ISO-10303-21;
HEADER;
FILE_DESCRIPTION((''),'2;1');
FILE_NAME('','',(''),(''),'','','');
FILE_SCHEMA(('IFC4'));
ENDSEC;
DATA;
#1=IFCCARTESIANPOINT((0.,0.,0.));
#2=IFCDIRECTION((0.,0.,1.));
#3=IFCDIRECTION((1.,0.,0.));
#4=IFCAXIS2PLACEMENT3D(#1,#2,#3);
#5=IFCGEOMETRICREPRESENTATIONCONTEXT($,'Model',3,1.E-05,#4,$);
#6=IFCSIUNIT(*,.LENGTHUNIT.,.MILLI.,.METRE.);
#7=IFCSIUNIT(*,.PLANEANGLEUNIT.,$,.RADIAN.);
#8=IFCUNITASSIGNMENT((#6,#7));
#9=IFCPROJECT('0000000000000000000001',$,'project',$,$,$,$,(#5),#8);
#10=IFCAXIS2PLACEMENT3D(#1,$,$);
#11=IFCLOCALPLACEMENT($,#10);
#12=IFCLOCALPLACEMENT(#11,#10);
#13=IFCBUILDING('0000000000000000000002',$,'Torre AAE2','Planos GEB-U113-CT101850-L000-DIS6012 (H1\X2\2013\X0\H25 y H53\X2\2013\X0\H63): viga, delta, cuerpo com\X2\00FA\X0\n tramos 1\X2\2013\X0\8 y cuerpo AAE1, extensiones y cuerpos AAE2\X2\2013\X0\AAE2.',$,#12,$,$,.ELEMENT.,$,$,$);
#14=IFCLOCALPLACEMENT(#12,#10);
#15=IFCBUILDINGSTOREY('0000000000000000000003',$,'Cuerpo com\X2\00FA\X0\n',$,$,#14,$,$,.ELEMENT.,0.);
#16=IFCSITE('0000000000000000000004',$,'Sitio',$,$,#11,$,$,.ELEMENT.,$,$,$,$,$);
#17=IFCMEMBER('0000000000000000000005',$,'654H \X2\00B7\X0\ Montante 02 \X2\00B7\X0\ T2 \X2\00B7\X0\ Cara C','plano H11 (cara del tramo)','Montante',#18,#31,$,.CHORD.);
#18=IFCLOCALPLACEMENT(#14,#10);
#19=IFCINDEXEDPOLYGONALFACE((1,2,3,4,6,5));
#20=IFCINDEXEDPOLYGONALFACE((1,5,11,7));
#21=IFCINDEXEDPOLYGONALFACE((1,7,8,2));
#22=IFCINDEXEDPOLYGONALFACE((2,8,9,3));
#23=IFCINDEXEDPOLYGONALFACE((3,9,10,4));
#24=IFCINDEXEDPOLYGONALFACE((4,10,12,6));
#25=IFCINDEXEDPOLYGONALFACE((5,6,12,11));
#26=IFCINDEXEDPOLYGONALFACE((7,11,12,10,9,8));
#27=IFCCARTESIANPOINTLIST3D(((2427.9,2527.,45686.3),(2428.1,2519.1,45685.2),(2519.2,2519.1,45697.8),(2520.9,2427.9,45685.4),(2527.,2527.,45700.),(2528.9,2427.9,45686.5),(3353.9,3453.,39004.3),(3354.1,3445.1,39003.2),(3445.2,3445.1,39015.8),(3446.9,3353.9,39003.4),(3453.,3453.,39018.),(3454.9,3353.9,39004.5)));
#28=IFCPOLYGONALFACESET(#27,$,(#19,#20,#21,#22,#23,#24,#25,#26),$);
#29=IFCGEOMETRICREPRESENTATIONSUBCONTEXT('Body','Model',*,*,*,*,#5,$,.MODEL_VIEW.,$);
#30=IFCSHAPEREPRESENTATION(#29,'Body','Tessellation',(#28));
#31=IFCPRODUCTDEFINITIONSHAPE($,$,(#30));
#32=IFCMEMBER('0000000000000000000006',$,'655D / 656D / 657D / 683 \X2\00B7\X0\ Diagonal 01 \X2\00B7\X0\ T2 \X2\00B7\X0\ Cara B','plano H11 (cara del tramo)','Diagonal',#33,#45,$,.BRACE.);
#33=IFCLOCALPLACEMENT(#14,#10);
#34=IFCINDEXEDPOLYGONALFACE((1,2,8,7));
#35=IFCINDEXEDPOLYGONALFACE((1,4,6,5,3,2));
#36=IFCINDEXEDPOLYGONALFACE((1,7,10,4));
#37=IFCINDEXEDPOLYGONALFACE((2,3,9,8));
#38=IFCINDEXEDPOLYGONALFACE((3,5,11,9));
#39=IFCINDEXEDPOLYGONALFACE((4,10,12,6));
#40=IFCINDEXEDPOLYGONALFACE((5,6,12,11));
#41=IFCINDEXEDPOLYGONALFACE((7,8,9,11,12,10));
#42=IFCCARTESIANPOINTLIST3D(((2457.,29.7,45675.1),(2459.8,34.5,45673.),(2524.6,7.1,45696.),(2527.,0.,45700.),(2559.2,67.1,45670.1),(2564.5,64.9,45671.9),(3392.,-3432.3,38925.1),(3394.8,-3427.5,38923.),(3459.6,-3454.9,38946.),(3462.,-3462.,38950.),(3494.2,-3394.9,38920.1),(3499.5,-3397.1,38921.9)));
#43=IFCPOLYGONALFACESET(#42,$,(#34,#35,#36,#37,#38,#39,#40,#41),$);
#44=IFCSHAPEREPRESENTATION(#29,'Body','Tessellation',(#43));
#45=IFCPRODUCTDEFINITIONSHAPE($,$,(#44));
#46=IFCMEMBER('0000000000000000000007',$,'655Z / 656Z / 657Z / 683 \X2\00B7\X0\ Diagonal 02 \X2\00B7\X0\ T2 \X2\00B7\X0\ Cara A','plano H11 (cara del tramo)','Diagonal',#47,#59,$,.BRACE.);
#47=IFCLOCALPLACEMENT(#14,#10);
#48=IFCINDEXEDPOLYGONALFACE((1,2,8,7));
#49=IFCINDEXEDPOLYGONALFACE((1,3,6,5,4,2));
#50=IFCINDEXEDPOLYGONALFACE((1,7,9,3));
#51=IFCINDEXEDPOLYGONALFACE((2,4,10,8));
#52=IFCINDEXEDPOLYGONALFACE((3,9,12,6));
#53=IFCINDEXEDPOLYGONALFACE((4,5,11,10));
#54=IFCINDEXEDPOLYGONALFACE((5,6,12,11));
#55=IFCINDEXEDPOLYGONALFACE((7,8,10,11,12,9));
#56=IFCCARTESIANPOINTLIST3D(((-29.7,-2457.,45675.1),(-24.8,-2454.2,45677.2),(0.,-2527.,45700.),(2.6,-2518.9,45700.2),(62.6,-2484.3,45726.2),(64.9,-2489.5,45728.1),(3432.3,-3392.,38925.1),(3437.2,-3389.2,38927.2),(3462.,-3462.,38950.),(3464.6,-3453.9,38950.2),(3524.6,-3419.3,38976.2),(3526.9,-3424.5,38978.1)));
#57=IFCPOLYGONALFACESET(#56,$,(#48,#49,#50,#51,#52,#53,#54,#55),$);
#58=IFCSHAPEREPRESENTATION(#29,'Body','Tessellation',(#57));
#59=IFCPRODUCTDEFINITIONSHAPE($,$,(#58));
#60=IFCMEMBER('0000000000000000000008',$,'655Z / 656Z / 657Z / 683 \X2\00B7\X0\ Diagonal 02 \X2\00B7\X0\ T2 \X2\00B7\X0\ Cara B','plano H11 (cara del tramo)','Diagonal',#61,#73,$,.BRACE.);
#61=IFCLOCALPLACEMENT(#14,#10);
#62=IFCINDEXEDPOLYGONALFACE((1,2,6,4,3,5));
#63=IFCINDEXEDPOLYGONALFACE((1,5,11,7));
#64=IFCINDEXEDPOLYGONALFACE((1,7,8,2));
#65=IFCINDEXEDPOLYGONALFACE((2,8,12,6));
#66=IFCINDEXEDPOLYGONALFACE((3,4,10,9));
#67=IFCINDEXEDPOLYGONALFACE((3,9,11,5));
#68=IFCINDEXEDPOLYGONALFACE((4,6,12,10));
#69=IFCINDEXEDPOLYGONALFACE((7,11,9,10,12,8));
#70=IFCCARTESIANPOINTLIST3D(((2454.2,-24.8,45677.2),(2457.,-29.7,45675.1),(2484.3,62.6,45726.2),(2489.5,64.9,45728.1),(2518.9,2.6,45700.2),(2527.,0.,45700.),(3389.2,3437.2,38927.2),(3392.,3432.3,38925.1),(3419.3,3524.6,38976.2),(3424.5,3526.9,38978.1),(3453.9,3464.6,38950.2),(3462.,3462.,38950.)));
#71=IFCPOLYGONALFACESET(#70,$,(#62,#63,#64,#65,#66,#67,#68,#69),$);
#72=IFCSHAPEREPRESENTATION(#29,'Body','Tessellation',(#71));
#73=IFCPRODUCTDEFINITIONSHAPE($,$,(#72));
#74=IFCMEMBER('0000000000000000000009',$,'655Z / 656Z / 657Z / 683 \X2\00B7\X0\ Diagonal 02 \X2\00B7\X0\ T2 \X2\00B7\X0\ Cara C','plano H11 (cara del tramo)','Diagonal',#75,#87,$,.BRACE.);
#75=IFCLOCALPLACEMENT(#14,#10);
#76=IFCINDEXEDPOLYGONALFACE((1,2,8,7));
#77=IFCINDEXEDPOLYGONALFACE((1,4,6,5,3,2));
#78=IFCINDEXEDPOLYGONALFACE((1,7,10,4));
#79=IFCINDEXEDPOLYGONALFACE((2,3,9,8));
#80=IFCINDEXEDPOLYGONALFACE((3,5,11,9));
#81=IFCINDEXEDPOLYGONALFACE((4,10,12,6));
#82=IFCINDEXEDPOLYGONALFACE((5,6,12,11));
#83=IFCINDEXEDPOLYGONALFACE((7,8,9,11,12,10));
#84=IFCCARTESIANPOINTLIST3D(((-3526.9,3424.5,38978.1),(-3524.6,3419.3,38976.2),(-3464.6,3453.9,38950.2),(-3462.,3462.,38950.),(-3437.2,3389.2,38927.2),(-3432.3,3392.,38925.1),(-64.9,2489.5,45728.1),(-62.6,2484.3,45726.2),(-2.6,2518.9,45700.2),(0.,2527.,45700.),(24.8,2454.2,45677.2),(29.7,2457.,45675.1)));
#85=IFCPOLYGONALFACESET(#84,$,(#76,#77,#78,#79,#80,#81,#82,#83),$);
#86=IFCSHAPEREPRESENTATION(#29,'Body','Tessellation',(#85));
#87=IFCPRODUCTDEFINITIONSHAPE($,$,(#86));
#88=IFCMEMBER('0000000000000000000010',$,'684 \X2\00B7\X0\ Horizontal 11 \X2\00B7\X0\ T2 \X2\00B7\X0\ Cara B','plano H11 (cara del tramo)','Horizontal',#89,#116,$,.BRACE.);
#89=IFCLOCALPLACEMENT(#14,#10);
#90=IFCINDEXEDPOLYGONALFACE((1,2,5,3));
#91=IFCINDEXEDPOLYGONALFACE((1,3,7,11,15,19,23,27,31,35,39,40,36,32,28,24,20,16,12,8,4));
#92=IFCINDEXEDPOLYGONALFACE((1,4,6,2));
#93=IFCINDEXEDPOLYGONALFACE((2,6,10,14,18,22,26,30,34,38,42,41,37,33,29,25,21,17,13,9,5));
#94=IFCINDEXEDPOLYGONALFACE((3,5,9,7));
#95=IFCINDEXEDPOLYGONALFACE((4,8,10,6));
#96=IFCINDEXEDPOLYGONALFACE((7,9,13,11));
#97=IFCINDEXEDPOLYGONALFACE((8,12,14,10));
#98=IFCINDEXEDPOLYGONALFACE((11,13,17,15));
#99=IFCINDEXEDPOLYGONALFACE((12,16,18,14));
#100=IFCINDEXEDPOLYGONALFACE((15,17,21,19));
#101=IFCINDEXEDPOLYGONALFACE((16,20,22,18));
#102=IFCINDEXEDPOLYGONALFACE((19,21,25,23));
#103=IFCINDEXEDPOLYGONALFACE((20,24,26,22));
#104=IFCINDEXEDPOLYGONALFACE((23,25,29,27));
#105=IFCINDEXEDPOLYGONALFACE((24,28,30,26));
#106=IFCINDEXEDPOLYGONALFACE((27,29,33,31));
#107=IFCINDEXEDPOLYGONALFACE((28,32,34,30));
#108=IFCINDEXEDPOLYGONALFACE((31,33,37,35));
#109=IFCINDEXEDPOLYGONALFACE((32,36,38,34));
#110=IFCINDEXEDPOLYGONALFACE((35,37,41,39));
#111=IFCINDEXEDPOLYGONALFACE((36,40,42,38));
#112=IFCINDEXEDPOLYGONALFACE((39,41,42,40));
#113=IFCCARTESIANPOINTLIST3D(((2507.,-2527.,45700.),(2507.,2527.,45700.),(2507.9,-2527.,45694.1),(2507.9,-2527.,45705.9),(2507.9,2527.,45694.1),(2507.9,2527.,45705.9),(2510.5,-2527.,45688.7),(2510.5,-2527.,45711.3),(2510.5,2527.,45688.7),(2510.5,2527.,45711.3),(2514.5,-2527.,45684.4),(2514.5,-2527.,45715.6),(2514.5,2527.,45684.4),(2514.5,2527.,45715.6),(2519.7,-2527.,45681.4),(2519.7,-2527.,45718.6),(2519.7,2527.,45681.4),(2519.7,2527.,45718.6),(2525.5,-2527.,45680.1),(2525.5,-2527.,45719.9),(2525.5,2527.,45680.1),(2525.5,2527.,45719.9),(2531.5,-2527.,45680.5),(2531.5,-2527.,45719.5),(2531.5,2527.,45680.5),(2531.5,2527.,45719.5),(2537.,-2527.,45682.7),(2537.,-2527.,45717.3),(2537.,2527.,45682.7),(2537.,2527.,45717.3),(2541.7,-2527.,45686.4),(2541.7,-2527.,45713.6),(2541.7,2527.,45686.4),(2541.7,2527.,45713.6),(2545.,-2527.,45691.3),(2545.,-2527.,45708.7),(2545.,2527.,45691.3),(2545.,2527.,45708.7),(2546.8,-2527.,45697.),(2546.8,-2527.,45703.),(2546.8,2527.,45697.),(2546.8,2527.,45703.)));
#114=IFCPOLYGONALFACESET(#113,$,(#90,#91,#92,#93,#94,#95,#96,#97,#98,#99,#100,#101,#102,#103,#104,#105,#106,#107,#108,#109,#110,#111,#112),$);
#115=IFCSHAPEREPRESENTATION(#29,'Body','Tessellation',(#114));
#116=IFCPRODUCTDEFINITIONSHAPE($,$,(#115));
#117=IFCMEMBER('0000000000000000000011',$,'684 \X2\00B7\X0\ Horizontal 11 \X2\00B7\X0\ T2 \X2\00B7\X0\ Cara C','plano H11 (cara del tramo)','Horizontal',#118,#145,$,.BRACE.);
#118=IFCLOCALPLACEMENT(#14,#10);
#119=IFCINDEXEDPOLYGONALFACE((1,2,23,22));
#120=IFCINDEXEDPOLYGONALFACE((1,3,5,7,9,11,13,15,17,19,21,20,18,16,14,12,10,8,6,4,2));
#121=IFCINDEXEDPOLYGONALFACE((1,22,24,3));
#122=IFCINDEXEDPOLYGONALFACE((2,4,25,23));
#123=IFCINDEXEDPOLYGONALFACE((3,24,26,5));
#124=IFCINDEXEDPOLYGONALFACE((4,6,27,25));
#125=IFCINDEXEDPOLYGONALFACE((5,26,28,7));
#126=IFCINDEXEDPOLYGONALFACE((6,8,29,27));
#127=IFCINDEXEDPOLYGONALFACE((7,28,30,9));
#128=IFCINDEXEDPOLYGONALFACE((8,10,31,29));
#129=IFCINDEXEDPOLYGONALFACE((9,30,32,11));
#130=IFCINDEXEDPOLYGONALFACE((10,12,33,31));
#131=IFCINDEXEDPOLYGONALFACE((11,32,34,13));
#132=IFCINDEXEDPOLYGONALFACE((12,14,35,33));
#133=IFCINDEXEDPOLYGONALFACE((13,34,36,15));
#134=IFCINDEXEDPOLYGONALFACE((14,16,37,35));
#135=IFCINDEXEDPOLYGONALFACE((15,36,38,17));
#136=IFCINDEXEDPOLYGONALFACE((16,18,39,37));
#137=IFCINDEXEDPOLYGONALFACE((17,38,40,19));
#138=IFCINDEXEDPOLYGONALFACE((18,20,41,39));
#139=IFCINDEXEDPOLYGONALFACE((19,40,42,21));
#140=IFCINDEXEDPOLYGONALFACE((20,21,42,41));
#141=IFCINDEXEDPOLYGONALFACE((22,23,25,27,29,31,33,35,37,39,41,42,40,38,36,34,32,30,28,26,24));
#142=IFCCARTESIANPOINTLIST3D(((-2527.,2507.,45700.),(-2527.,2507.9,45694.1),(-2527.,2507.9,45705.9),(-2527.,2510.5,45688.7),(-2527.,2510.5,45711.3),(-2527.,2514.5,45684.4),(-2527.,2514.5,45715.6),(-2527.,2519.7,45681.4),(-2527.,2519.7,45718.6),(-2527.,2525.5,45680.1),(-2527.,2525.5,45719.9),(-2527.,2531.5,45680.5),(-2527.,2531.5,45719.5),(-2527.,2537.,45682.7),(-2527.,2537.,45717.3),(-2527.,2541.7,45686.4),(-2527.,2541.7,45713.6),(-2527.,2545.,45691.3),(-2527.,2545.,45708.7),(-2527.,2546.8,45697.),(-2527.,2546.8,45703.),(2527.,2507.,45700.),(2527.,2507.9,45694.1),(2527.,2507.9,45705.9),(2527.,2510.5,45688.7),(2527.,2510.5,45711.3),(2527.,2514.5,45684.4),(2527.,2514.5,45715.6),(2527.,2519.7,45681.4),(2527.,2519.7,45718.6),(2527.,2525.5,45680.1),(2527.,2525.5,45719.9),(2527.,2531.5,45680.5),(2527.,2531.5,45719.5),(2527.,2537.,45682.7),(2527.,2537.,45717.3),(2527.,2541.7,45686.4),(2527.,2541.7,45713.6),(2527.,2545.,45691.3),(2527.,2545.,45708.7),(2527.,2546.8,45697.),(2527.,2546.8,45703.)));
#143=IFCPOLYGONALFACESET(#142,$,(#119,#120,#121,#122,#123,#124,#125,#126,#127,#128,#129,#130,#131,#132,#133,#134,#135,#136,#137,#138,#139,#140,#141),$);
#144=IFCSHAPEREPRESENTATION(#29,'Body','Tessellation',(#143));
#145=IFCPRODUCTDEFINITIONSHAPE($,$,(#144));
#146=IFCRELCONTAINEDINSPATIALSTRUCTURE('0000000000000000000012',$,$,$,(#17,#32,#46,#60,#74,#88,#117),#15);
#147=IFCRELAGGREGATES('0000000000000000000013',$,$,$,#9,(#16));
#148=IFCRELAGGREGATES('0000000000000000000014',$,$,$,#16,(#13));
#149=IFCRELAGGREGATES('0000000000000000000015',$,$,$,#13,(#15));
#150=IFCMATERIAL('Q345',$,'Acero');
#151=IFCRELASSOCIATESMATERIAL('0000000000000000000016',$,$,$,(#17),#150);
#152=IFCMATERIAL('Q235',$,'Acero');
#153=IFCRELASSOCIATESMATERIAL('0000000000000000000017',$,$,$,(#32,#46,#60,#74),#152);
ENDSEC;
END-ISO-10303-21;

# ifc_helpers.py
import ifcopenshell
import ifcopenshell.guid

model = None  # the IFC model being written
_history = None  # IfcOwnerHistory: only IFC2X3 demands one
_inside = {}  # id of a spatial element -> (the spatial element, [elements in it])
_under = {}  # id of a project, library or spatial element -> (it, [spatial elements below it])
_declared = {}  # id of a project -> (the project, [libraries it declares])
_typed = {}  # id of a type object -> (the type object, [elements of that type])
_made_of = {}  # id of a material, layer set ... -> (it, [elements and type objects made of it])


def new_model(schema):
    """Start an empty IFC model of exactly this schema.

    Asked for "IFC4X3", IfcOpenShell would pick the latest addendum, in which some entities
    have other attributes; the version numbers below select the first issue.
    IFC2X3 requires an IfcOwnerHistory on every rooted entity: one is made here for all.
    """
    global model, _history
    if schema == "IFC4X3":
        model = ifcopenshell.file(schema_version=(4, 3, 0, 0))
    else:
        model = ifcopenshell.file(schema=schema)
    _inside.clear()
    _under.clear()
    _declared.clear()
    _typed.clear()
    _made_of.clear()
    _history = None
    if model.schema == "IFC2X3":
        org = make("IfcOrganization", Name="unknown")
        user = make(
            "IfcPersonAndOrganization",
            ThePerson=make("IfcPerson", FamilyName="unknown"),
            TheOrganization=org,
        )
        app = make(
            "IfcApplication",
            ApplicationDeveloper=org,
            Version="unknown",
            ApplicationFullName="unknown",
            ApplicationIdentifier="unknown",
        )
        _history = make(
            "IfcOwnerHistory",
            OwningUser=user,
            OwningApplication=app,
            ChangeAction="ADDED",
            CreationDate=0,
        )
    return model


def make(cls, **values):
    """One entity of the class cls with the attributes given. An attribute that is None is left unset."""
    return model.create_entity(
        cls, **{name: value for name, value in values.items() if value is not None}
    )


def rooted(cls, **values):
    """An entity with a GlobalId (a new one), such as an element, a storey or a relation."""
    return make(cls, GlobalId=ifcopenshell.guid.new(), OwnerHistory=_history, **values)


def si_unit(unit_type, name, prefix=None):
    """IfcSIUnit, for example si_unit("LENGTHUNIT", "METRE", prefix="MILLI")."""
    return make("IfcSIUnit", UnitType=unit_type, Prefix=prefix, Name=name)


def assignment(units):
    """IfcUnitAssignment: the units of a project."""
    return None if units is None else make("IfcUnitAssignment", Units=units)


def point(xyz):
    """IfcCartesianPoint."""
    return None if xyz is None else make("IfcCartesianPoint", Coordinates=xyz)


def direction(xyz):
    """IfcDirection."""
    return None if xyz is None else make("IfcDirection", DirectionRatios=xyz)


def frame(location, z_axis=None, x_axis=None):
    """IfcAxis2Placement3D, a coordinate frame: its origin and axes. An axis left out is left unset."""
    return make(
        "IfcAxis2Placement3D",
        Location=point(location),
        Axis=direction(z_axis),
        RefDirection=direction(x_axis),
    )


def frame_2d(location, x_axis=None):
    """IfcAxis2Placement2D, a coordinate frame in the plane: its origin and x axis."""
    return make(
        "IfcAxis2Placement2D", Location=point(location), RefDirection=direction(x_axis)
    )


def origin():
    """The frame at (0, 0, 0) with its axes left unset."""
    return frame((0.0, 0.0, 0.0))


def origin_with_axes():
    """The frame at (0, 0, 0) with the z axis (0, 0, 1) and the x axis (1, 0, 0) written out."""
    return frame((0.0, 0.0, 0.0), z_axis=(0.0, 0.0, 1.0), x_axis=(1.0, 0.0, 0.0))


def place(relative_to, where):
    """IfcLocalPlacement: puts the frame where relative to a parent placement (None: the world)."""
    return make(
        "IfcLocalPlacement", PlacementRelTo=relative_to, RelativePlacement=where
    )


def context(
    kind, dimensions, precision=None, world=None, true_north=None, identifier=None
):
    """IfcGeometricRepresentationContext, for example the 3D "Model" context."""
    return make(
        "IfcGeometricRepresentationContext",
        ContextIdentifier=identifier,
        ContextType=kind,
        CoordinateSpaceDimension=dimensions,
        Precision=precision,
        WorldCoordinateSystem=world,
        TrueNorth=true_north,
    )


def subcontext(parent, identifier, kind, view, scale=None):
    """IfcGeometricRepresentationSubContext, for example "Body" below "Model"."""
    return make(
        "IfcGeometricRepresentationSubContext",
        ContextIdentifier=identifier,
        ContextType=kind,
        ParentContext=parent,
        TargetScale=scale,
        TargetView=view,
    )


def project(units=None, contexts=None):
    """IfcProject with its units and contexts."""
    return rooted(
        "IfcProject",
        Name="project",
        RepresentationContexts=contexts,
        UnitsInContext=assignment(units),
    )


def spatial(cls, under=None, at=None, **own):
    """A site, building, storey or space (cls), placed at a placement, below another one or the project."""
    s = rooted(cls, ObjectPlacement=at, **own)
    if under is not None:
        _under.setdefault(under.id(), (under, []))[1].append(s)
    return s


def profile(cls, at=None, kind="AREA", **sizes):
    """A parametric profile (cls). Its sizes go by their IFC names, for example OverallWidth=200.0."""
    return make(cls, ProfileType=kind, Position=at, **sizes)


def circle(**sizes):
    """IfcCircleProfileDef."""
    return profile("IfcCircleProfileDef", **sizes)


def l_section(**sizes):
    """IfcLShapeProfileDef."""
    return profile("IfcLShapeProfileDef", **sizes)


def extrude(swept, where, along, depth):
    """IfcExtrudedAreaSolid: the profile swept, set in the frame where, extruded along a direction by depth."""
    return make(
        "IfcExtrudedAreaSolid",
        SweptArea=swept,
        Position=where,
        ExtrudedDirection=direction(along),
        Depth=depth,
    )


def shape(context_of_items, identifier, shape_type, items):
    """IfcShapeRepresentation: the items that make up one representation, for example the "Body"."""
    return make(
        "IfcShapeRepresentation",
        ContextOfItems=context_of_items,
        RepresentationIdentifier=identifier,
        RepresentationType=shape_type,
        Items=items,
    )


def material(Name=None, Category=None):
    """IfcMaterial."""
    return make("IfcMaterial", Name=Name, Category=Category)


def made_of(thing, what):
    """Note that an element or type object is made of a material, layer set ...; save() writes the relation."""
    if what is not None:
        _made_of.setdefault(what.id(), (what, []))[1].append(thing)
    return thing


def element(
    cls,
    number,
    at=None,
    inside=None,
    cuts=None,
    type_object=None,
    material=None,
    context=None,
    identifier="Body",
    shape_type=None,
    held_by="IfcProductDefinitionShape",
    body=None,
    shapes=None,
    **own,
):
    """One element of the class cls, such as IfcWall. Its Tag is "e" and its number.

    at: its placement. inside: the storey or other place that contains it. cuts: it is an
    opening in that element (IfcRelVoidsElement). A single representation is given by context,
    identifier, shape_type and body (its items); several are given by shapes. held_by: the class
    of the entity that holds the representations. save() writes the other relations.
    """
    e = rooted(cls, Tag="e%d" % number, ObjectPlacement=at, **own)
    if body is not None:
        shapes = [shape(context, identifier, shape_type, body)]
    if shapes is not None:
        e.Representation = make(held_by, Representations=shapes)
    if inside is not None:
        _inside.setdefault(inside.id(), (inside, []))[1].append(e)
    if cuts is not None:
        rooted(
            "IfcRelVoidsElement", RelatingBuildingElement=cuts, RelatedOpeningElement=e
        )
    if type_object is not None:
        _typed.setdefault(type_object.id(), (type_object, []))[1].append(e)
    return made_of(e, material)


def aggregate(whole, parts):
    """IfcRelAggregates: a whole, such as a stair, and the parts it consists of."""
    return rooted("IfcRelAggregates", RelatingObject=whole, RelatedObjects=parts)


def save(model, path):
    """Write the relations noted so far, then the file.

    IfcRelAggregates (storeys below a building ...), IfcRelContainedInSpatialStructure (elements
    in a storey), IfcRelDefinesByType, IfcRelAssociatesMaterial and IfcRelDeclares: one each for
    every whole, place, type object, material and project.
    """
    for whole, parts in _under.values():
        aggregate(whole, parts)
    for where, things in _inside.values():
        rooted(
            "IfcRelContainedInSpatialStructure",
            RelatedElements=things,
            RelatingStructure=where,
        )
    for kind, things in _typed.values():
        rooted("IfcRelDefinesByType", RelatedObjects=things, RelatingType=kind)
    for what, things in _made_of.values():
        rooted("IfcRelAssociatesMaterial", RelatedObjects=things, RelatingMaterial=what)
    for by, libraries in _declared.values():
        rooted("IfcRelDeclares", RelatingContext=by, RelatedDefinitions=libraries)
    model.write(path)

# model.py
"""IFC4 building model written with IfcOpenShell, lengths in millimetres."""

from ifc_helpers import new_model, si_unit, frame, frame_2d, origin, origin_with_axes, place, context, subcontext, project, spatial, circle, l_section, extrude, material, element, save


model = new_model("IFC4")

# Units and contexts
model_context = context("Model", 3, precision=1e-05, world=origin_with_axes())
body_context = subcontext(model_context, "Body", "Model", "MODEL_VIEW")
ifc_project = project(units=[si_unit("LENGTHUNIT", "METRE", prefix="MILLI"), si_unit("PLANEANGLEUNIT", "RADIAN")], contexts=[model_context])

# Site, building, storey
site_placement = place(None, origin())
site = spatial("IfcSite", under=ifc_project, at=site_placement, Name="Sitio", CompositionType="ELEMENT")
building_placement = place(site_placement, origin())
building = spatial("IfcBuilding", under=site, at=building_placement, Name="Torre AAE2", Description="Planos GEB-U113-CT101850-L000-DIS6012 (H1–H25 y H53–H63): viga, delta, cuerpo común tramos 1–8 y cuerpo AAE1, extensiones y cuerpos AAE2–AAE2.", CompositionType="ELEMENT")
storey_placement = place(building_placement, origin())
storey = spatial("IfcBuildingStorey", under=building, at=storey_placement, Name="Cuerpo común", CompositionType="ELEMENT", Elevation=0.0)

# Members
ifc_material_1 = material(Name="Q235", Category="Acero")
ifc_material_2 = material(Name="Q345", Category="Acero")
for number, where, z_axis, x_axis, name in (
    (1, (2527.0, 2527.0, 45700.0), (0.135994, 0.135994, -0.981331), (0.018668, -0.99071, -0.134707), "654H · Montante 02 · T2 · Cara C"),
):
    element("IfcMember", number, at=place(storey_placement, frame(where, z_axis=z_axis, x_axis=x_axis)), inside=storey, material=ifc_material_2, Name=name, Description="plano H11 (cara del tramo)", ObjectType="Montante", PredefinedType="CHORD", context=body_context, shape_type="SweptSolid", body=[
        extrude(l_section(Depth=100.0, Width=100.0, Thickness=8.0, at=frame_2d((50.0, 50.0))), None, (0.0, 0.0, 1.0), 6809.1),
    ])
for number, where, z_axis, x_axis, name in (
    (2, (2527.0, 0.0, 45700.0), (0.122327, -0.452937, -0.88311), (-0.874879, 0.370937, -0.311437), "655D / 656D / 657D / 683 · Diagonal 01 · T2 · Cara B"),
    (3, (0.0, -2527.0, 45700.0), (0.452937, -0.122327, -0.88311), (-0.370937, 0.874879, -0.311437), "655Z / 656Z / 657Z / 683 · Diagonal 02 · T2 · Cara A"),
    (4, (2527.0, 0.0, 45700.0), (0.122327, 0.452937, -0.88311), (-0.874879, -0.370937, -0.311437), "655Z / 656Z / 657Z / 683 · Diagonal 02 · T2 · Cara B"),
    (5, (0.0, 2527.0, 45700.0), (-0.452937, 0.122327, -0.88311), (0.370937, -0.874879, -0.311437), "655Z / 656Z / 657Z / 683 · Diagonal 02 · T2 · Cara C"),
):
    element("IfcMember", number, at=place(storey_placement, frame(where, z_axis=z_axis, x_axis=x_axis)), inside=storey, material=ifc_material_1, Name=name, Description="plano H11 (cara del tramo)", ObjectType="Diagonal", PredefinedType="BRACE", context=body_context, shape_type="SweptSolid", body=[
        extrude(l_section(Depth=80.0, Width=80.0, Thickness=6.0, at=frame_2d((40.0, 40.0))), None, (0.0, 0.0, 1.0), 7643.4),
    ])
for number, where, z_axis, x_axis, name in (
    (6, (2527.0, -2527.0, 45700.0), (0.0, 1.0, 0.0), (-1.0, 0.0, 0.0), "684 · Horizontal 11 · T2 · Cara B"),
    (7, (2527.0, 2527.0, 45700.0), (-1.0, 0.0, 0.0), (0.0, -1.0, 0.0), "684 · Horizontal 11 · T2 · Cara C"),
):
    element("IfcMember", number, at=place(storey_placement, frame(where, z_axis=z_axis, x_axis=x_axis)), inside=storey, Name=name, Description="plano H11 (cara del tramo)", ObjectType="Horizontal", PredefinedType="BRACE", context=body_context, shape_type="SweptSolid", body=[
        extrude(circle(Radius=20.0), None, (0.0, 0.0, 1.0), 5054.0),
    ])

save(model, "model.ifc")
